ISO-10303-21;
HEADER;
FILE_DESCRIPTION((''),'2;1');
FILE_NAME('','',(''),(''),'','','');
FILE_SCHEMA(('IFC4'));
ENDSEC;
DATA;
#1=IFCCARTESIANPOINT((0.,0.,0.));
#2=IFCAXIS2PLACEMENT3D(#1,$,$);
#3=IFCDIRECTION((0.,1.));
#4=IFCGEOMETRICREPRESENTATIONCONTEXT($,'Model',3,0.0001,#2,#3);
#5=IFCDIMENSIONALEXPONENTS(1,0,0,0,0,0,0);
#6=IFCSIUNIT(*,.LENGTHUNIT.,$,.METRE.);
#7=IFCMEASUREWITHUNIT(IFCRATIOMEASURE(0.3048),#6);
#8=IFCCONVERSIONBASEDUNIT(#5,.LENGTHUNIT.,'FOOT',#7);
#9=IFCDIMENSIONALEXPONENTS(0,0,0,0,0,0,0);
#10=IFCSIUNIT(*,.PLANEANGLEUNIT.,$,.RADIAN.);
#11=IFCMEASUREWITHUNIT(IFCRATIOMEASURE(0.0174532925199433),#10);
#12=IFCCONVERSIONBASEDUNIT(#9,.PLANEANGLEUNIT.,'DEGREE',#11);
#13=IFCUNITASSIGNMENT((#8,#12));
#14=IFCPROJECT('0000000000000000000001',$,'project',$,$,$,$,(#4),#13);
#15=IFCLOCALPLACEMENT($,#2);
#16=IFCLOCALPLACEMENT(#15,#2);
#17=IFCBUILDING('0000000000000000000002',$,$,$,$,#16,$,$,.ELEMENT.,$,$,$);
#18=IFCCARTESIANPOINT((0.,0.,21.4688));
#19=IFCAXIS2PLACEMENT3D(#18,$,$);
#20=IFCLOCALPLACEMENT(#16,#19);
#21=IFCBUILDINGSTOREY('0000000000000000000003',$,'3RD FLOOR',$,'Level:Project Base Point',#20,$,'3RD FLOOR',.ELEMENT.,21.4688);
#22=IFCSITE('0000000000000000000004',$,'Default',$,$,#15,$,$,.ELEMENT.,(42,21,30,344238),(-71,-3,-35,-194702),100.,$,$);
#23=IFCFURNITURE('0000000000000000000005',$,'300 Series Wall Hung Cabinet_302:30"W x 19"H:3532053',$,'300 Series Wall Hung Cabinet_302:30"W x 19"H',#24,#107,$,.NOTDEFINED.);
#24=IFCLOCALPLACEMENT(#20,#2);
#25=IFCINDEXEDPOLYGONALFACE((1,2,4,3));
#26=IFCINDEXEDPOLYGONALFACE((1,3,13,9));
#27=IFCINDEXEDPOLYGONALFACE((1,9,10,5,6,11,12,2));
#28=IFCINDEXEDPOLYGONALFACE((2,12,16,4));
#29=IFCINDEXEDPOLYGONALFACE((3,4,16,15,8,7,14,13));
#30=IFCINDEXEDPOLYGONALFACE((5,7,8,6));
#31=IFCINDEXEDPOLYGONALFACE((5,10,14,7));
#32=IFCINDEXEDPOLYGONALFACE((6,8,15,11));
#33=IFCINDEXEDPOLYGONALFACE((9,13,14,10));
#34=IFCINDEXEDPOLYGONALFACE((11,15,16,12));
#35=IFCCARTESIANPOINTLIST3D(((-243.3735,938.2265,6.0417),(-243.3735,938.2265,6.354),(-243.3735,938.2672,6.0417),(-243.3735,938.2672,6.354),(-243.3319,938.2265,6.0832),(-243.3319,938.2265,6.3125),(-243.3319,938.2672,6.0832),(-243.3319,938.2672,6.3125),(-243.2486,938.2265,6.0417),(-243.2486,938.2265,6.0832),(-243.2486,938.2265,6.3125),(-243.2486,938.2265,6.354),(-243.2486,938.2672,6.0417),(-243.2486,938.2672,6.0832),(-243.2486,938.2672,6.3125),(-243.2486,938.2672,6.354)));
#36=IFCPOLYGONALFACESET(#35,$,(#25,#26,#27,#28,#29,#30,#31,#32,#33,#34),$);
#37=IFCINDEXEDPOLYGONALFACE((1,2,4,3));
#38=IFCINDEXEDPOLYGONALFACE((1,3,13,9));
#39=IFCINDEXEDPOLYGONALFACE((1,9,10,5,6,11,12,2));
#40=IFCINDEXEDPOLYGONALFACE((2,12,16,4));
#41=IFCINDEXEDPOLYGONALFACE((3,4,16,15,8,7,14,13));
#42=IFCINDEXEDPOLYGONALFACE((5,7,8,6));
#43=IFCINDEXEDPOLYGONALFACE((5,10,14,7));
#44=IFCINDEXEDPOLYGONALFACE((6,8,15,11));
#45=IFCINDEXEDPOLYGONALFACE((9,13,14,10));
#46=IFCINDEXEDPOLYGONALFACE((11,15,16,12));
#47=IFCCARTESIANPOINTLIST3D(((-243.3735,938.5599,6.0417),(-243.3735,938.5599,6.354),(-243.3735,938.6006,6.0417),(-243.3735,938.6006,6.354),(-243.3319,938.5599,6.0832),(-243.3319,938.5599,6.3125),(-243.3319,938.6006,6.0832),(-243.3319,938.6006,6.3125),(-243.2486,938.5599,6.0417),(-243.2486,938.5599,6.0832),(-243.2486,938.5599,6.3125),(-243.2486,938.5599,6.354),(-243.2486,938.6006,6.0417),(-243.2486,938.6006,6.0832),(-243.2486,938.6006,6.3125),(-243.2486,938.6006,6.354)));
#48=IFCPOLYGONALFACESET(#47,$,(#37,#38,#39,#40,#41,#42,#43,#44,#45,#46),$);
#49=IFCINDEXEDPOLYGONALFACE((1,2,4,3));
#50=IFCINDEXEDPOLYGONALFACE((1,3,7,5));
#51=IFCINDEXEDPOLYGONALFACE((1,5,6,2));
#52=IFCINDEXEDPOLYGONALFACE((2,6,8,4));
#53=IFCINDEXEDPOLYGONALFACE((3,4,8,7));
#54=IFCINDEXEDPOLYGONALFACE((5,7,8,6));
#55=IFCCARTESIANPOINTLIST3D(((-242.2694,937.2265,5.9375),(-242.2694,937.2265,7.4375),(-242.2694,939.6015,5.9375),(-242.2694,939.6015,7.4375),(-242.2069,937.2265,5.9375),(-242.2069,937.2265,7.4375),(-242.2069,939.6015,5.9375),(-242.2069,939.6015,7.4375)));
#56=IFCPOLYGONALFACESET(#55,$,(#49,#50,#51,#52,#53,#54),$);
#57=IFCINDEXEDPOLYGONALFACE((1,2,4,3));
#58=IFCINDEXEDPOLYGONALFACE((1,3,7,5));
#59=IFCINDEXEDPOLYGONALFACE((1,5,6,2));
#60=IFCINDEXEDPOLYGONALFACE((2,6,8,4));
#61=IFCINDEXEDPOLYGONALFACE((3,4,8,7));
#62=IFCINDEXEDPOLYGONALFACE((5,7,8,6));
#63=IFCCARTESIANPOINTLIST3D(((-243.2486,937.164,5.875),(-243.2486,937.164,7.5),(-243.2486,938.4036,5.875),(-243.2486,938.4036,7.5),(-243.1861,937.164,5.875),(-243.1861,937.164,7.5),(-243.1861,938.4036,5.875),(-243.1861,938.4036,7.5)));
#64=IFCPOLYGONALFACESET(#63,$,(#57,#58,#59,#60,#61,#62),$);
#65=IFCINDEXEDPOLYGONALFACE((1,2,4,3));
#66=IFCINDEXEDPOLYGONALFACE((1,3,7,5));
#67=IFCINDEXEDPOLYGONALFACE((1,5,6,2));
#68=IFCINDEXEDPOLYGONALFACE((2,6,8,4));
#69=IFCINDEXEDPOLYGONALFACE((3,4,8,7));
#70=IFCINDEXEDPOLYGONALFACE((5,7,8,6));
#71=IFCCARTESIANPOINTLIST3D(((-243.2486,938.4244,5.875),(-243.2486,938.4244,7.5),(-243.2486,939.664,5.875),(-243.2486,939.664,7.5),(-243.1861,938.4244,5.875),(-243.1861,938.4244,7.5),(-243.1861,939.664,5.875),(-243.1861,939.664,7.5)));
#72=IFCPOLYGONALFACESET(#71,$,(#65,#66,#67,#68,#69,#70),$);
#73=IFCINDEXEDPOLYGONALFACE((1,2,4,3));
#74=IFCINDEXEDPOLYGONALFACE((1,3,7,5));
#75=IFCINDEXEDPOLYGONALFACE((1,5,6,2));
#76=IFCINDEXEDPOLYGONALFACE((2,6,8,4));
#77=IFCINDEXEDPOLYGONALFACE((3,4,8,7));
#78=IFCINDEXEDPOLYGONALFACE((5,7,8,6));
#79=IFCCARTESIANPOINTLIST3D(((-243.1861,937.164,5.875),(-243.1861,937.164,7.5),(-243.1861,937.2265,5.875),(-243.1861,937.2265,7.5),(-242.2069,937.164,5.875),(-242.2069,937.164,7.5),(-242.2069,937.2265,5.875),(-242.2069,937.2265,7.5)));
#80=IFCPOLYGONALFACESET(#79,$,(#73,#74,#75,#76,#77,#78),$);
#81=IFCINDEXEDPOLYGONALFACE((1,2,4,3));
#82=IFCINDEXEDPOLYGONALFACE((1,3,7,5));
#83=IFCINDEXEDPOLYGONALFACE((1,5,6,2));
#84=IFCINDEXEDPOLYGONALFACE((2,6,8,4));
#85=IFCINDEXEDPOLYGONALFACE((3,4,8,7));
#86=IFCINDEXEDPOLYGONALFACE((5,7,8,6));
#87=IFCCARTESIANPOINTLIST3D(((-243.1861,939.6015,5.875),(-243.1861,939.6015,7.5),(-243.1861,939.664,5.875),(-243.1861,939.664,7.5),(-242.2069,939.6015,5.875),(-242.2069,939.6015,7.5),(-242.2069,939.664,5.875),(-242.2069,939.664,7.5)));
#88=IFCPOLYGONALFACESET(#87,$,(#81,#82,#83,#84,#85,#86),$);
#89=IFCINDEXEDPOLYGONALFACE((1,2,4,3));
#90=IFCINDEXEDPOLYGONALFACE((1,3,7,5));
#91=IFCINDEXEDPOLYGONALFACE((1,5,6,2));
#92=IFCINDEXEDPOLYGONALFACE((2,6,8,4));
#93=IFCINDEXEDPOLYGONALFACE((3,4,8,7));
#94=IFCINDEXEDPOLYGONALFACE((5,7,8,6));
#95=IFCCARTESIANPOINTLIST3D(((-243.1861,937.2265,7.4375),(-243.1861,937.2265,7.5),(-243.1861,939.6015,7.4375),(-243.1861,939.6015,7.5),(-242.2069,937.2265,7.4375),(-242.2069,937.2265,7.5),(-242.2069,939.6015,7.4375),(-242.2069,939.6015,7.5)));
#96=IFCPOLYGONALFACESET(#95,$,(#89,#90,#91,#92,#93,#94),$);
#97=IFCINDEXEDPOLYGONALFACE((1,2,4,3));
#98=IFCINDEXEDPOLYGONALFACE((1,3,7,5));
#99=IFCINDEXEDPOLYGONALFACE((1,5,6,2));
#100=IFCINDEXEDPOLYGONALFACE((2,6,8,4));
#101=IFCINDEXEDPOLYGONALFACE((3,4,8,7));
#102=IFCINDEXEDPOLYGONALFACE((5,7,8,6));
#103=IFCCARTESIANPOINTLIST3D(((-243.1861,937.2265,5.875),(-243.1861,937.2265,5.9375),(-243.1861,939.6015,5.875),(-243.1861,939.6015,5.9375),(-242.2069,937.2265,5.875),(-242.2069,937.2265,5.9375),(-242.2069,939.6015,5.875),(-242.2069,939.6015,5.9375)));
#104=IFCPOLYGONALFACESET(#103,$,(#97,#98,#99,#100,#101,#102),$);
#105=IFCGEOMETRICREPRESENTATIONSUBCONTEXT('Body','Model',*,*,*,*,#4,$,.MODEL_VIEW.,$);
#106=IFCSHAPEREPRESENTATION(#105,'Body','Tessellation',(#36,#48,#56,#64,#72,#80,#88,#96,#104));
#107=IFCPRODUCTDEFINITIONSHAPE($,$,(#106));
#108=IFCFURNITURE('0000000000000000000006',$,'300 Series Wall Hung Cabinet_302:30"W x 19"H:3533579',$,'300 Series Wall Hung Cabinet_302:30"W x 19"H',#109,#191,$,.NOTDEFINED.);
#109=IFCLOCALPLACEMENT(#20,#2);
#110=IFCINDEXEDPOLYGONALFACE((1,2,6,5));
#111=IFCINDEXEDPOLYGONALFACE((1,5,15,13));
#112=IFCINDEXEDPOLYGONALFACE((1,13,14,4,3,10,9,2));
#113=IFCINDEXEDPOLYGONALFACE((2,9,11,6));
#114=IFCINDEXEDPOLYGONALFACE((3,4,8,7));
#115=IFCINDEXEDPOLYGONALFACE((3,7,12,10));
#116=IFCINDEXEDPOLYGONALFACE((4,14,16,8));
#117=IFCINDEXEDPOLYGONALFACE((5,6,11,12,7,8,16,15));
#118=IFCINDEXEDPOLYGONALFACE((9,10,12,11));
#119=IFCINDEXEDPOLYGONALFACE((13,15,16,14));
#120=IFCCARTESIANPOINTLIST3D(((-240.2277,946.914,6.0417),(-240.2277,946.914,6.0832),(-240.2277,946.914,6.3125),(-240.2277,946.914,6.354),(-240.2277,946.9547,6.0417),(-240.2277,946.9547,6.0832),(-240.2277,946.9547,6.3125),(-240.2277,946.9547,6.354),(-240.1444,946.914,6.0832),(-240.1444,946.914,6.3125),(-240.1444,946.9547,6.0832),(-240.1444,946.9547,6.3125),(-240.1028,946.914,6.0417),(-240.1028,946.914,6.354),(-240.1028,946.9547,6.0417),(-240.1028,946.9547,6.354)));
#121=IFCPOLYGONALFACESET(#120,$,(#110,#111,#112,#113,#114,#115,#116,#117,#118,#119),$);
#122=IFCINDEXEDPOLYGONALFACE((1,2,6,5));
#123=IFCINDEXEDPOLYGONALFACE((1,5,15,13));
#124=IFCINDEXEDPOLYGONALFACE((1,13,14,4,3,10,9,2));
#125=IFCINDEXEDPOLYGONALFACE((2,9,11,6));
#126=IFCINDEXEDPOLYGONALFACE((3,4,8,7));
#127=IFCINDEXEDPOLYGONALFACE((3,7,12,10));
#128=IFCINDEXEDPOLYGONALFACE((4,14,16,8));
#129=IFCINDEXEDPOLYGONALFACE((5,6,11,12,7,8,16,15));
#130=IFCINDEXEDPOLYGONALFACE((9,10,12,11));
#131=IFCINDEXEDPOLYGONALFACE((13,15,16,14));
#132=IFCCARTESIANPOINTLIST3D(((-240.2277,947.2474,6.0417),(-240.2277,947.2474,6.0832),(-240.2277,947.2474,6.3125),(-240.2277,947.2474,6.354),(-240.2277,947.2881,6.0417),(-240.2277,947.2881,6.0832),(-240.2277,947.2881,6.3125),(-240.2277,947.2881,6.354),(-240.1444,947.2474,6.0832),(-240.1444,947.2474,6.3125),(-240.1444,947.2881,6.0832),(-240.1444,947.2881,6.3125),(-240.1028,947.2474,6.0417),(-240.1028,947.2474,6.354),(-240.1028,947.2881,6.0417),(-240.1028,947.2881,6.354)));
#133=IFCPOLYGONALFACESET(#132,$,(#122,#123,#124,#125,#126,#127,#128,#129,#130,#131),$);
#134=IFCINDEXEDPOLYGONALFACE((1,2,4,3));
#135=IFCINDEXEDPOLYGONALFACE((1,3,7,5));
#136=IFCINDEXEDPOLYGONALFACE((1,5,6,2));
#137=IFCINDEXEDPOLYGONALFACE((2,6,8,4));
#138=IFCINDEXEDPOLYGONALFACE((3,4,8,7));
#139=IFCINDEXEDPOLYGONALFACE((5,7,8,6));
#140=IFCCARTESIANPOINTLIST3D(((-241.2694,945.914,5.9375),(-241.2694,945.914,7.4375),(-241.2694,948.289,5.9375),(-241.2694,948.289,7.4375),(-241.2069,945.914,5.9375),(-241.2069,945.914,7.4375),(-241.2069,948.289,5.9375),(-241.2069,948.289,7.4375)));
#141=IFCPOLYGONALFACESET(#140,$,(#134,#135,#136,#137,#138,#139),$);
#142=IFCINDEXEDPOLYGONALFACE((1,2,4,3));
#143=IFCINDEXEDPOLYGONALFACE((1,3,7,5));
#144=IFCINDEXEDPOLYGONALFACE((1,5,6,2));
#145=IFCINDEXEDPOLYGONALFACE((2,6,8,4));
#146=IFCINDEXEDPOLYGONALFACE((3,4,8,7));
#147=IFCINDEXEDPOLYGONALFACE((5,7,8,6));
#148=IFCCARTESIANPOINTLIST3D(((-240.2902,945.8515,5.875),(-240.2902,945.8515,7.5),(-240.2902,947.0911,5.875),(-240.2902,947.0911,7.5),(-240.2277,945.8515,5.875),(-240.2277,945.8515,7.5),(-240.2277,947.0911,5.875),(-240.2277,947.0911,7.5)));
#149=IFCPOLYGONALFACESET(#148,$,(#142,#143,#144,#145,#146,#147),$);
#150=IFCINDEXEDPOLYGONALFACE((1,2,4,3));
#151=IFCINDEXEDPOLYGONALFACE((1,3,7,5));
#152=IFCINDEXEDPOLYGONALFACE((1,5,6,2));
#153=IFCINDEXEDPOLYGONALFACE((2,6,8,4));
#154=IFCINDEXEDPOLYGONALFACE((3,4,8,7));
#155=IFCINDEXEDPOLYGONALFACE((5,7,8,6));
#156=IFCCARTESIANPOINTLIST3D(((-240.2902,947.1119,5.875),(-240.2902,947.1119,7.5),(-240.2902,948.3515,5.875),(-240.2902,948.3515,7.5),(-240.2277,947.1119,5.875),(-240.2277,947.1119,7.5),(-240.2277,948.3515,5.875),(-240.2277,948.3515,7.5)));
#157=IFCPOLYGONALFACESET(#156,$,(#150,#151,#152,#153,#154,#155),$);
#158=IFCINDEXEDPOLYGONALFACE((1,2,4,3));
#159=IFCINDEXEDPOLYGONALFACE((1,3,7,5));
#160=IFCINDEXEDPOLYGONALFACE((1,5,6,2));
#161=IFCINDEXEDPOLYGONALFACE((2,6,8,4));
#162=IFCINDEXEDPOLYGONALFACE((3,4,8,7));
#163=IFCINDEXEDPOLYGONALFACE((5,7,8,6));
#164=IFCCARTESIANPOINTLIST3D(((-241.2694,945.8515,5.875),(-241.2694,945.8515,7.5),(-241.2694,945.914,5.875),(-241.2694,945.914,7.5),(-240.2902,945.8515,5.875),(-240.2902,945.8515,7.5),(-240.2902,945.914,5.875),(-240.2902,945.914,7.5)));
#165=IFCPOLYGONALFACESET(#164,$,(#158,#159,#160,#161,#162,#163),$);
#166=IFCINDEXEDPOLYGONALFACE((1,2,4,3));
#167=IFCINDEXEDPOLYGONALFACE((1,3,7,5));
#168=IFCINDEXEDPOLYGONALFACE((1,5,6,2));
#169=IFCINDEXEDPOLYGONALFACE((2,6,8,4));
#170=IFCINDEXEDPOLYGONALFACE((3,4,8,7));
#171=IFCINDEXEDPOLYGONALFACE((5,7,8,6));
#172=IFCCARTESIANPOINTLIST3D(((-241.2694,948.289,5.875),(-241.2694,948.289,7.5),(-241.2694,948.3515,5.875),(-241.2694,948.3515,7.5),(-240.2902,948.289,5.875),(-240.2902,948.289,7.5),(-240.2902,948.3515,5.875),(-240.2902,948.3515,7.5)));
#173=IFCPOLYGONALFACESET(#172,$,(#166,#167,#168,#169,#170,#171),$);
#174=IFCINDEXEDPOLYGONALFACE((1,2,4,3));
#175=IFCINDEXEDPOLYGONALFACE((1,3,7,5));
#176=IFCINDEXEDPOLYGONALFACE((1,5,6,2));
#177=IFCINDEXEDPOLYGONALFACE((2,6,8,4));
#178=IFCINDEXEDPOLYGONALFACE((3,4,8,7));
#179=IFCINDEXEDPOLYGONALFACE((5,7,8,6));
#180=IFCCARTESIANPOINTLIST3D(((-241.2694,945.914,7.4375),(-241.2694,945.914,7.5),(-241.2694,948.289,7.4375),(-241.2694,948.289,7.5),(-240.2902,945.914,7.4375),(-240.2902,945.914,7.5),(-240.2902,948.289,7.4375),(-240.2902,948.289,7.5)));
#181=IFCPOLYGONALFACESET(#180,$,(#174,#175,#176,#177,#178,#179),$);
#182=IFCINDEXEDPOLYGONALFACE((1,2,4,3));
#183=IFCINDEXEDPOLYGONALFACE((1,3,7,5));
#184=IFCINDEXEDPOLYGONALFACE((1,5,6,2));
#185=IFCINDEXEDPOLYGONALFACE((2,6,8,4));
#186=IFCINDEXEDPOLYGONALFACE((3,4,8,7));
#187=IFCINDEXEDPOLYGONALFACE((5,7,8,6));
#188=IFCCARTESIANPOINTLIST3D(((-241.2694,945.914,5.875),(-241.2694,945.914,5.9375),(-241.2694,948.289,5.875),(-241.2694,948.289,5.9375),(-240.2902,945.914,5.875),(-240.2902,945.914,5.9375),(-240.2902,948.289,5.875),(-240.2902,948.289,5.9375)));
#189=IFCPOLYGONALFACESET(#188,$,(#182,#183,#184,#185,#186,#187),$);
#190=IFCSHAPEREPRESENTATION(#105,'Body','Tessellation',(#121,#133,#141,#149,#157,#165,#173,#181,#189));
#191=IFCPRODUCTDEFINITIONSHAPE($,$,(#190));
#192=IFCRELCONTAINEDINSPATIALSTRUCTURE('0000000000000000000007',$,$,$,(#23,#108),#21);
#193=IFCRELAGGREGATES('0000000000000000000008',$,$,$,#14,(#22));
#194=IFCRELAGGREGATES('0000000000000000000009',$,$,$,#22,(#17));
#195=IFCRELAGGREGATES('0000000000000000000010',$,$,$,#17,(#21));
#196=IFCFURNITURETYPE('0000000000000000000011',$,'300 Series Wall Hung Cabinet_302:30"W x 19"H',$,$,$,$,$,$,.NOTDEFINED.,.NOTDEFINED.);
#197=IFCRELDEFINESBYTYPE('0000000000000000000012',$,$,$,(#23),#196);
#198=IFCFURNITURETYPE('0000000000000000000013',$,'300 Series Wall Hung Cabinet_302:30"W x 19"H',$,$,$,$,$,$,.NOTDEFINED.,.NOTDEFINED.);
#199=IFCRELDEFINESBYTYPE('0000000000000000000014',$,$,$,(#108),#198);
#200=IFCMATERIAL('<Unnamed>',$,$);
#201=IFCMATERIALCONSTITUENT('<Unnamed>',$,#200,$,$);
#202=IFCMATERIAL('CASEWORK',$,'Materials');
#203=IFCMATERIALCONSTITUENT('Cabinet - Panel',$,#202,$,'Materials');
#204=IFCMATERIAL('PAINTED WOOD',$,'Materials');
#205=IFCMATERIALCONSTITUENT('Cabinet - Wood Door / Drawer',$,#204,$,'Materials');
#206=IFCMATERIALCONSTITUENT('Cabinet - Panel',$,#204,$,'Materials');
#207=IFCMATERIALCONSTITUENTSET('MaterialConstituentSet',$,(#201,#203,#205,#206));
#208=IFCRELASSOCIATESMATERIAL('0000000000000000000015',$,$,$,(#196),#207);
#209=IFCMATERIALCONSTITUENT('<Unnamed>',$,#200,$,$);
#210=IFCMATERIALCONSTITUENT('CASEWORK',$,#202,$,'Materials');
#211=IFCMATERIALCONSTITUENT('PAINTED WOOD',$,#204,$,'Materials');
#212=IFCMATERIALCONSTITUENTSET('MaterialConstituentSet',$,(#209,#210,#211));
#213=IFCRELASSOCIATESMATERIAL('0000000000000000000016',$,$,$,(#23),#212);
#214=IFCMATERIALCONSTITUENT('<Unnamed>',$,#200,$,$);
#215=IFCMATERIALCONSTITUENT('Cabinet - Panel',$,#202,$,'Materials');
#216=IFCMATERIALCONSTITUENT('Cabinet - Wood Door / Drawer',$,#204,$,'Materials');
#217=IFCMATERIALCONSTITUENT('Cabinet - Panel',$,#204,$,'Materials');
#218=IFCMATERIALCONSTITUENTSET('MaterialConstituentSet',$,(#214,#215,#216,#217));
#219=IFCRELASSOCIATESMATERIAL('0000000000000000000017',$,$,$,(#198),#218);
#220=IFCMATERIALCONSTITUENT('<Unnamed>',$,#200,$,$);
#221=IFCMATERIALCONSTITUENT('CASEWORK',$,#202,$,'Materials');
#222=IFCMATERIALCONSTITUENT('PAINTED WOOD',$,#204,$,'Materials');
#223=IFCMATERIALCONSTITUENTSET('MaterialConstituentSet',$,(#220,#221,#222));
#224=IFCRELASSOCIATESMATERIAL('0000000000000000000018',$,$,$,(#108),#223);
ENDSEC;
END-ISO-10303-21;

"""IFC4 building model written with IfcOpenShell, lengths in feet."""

from ifc_helpers import new_model, entity, si_unit, converted_unit, direction, frame, frame_2d, origin, origin_2d_with_axis, place, context, subcontext, project, spatial, polyline, rectangle, outline, extrude, source, transform, mapped, material, constituent, constituent_set, type_object, type_shapes, element, save


model = new_model("IFC4")

# Units and contexts
model_context = context("Model", 3, precision=0.0001, world=origin(), true_north=direction((0.0, 1.0)))
body_context = subcontext(model_context, "Body", "Model", "MODEL_VIEW")
ifc_project = project(units=[converted_unit("LENGTHUNIT", "FOOT", entity("IfcRatioMeasure", 0.3048), si_unit("LENGTHUNIT", "METRE"), dimensions=[1, 0, 0, 0, 0, 0, 0]), converted_unit("PLANEANGLEUNIT", "DEGREE", entity("IfcRatioMeasure", 0.0174532925199433), si_unit("PLANEANGLEUNIT", "RADIAN"), dimensions=[0, 0, 0, 0, 0, 0, 0])], contexts=[model_context])

# Site, building, storey
site_placement = place(None, origin())
site = spatial("IfcSite", under=ifc_project, at=site_placement, Name="Default", CompositionType="ELEMENT", RefLatitude=(42, 21, 30, 344238), RefLongitude=(-71, -3, -35, -194702), RefElevation=100.0)
building_placement = place(site_placement, origin())
building = spatial("IfcBuilding", under=site, at=building_placement, CompositionType="ELEMENT")
storey_placement = place(building_placement, frame((0.0, 0.0, 21.4688)))
storey = spatial("IfcBuildingStorey", under=building, at=storey_placement, Name="3RD FLOOR", ObjectType="Level:Project Base Point", LongName="3RD FLOOR", CompositionType="ELEMENT", Elevation=21.4688)

# Furniture
ifc_material_1 = material(Name="CASEWORK", Category="Materials")
ifc_material_2 = material(Name="<Unnamed>")
ifc_material_3 = material(Name="PAINTED WOOD", Category="Materials")
ifc_constituent_1 = constituent(ifc_material_2, Name="<Unnamed>")
ifc_constituent_2 = constituent(ifc_material_1, Name="CASEWORK", Category="Materials")
ifc_constituent_3 = constituent(ifc_material_3, Name="PAINTED WOOD", Category="Materials")
ifc_constituent_set_1 = constituent_set(constituents=[ifc_constituent_1, ifc_constituent_2, ifc_constituent_3], Name="MaterialConstituentSet")
ifc_constituent_4 = constituent(ifc_material_2, Name="<Unnamed>")
ifc_constituent_5 = constituent(ifc_material_1, Name="Cabinet - Panel", Category="Materials")
ifc_constituent_6 = constituent(ifc_material_3, Name="Cabinet - Wood Door / Drawer", Category="Materials")
ifc_constituent_7 = constituent(ifc_material_3, Name="Cabinet - Panel", Category="Materials")
ifc_constituent_set_2 = constituent_set(constituents=[ifc_constituent_4, ifc_constituent_5, ifc_constituent_6, ifc_constituent_7], Name="MaterialConstituentSet")
furniture_type_1 = type_object("IfcFurnitureType", Name="300 Series Wall Hung Cabinet_302:30\"W x 19\"H", AssemblyPlace="NOTDEFINED", PredefinedType="NOTDEFINED", material=ifc_constituent_set_2)
shared_shape_1 = source(origin(), body_context, "Body", "SweptSolid", [
    extrude(outline(polyline([(-0.0521, -0.1146), (-0.0521, -0.1562), (0.0729, -0.1562), (0.0729, 0.1562), (-0.0521, 0.1562), (-0.0521, 0.1146), (0.0313, 0.1146), (0.0313, -0.1146), (-0.0521, -0.1146)])), frame((1.0625, 1.0937, 0.3229), z_axis=(-1.0, 0.0, 0.0), x_axis=(0.0, 1.0, 0.0)), (0.0, 0.0, -1.0), 0.0407),
    extrude(outline(polyline([(-0.0521, -0.1146), (-0.0521, -0.1562), (0.0729, -0.1562), (0.0729, 0.1562), (-0.0521, 0.1562), (-0.0521, 0.1146), (0.0313, 0.1146), (0.0313, -0.1146), (-0.0521, -0.1146)])), frame((1.3958, 1.0937, 0.3229), z_axis=(-1.0, 0.0, 0.0), x_axis=(0.0, 1.0, 0.0)), (0.0, 0.0, -1.0), 0.0407),
    extrude(rectangle(XDim=0.0625, YDim=2.375, at=frame_2d((0.0, 0.0), x_axis=(1.0, 0.0))), frame((1.25, 0.0313, 0.0625), z_axis=(0.0, 0.0, 1.0), x_axis=(0.0, 1.0, 0.0)), (0.0, 0.0, 1.0), 1.5),
    extrude(rectangle(XDim=0.0625, YDim=1.2396, at=origin_2d_with_axis()), frame((0.6198, 1.0104, 0.0), z_axis=(0.0, 0.0, 1.0), x_axis=(0.0, 1.0, 0.0)), (0.0, 0.0, 1.0), 1.625),
    extrude(rectangle(XDim=0.0625, YDim=1.2396, at=frame_2d((0.0, 0.0), x_axis=(1.0, 0.0))), frame((1.8802, 1.0104, 0.0), z_axis=(0.0, 0.0, 1.0), x_axis=(0.0, 1.0, 0.0)), (0.0, 0.0, 1.0), 1.625),
    extrude(rectangle(XDim=0.0625, YDim=0.9792, at=frame_2d((0.0, 0.0), x_axis=(1.0, 0.0))), frame((0.0313, 0.4896, 0.0)), (0.0, 0.0, 1.0), 1.625),
    extrude(rectangle(XDim=0.0625, YDim=0.9792, at=frame_2d((0.0, 0.0), x_axis=(1.0, 0.0))), frame((2.4688, 0.4896, 0.0)), (0.0, 0.0, 1.0), 1.625),
    extrude(rectangle(XDim=2.375, YDim=0.9792, at=frame_2d((0.0, 0.0), x_axis=(1.0, 0.0))), frame((1.25, 0.4896, 1.5625), z_axis=(0.0, 0.0, 1.0), x_axis=(-1.0, 0.0, 0.0)), (0.0, 0.0, 1.0), 0.0625),
    extrude(rectangle(XDim=2.375, YDim=0.9792, at=frame_2d((0.0, 0.0), x_axis=(1.0, 0.0))), frame((1.25, 0.4896, 0.0), z_axis=(0.0, 0.0, 1.0), x_axis=(-1.0, 0.0, 0.0)), (0.0, 0.0, 1.0), 0.0625),
])
type_shapes(furniture_type_1, [shared_shape_1])
furniture_1_placement = place(storey_placement, frame((-242.2069, 937.164, 5.875), z_axis=(0.0, 0.0, 1.0), x_axis=(0.0, 1.0, 0.0)))
element("IfcFurniture", 1, at=furniture_1_placement, inside=storey, type_object=furniture_type_1, material=ifc_constituent_set_1, Name="300 Series Wall Hung Cabinet_302:30\"W x 19\"H:3532053", ObjectType="300 Series Wall Hung Cabinet_302:30\"W x 19\"H", PredefinedType="NOTDEFINED", context=body_context, shape_type="MappedRepresentation", body=[
    mapped(shared_shape_1, transform((0.0, 0.0, 0.0), scale=1.0)),
])
ifc_constituent_8 = constituent(ifc_material_2, Name="<Unnamed>")
ifc_constituent_9 = constituent(ifc_material_1, Name="CASEWORK", Category="Materials")
ifc_constituent_10 = constituent(ifc_material_3, Name="PAINTED WOOD", Category="Materials")
ifc_constituent_set_3 = constituent_set(constituents=[ifc_constituent_8, ifc_constituent_9, ifc_constituent_10], Name="MaterialConstituentSet")
ifc_constituent_11 = constituent(ifc_material_2, Name="<Unnamed>")
ifc_constituent_12 = constituent(ifc_material_1, Name="Cabinet - Panel", Category="Materials")
ifc_constituent_13 = constituent(ifc_material_3, Name="Cabinet - Wood Door / Drawer", Category="Materials")
ifc_constituent_14 = constituent(ifc_material_3, Name="Cabinet - Panel", Category="Materials")
ifc_constituent_set_4 = constituent_set(constituents=[ifc_constituent_11, ifc_constituent_12, ifc_constituent_13, ifc_constituent_14], Name="MaterialConstituentSet")
furniture_type_2 = type_object("IfcFurnitureType", Name="300 Series Wall Hung Cabinet_302:30\"W x 19\"H", AssemblyPlace="NOTDEFINED", PredefinedType="NOTDEFINED", material=ifc_constituent_set_4)
shared_shape_2 = source(origin(), body_context, "Body", "SweptSolid", [
    extrude(outline(polyline([(0.1146, -0.0521), (0.1562, -0.0521), (0.1562, 0.0729), (-0.1562, 0.0729), (-0.1562, -0.0521), (-0.1146, -0.0521), (-0.1146, 0.0313), (0.1146, 0.0313), (0.1146, -0.0521)])), frame((1.0625, 0.0729, 0.3229), z_axis=(1.0, 0.0, 0.0), x_axis=(0.0, 0.0, 1.0)), (0.0, 0.0, 1.0), 0.0407),
    extrude(outline(polyline([(0.1146, -0.0521), (0.1562, -0.0521), (0.1562, 0.0729), (-0.1562, 0.0729), (-0.1562, -0.0521), (-0.1146, -0.0521), (-0.1146, 0.0313), (0.1146, 0.0313), (0.1146, -0.0521)])), frame((1.3958, 0.0729, 0.3229), z_axis=(1.0, 0.0, 0.0), x_axis=(0.0, 0.0, 1.0)), (0.0, 0.0, 1.0), 0.0407),
    extrude(rectangle(XDim=2.375, YDim=0.0625, at=origin_2d_with_axis()), frame((1.25, 1.1354, 0.0625), z_axis=(0.0, 0.0, 1.0), x_axis=(-1.0, 0.0, 0.0)), (0.0, 0.0, 1.0), 1.5),
    extrude(rectangle(XDim=1.2396, YDim=0.0625, at=origin_2d_with_axis()), frame((0.6198, 0.1562, 0.0), z_axis=(0.0, 0.0, 1.0), x_axis=(-1.0, 0.0, 0.0)), (0.0, 0.0, 1.0), 1.625),
    extrude(rectangle(XDim=1.2396, YDim=0.0625, at=frame_2d((0.0, 0.0), x_axis=(1.0, 0.0))), frame((1.8802, 0.1562, 0.0), z_axis=(0.0, 0.0, 1.0), x_axis=(-1.0, 0.0, 0.0)), (0.0, 0.0, 1.0), 1.625),
    extrude(rectangle(XDim=0.9792, YDim=0.0625, at=frame_2d((0.0, 0.0), x_axis=(1.0, 0.0))), frame((0.0313, 0.677, 0.0), z_axis=(0.0, 0.0, 1.0), x_axis=(0.0, -1.0, 0.0)), (0.0, 0.0, 1.0), 1.625),
    extrude(rectangle(XDim=0.9792, YDim=0.0625, at=frame_2d((0.0, 0.0), x_axis=(1.0, 0.0))), frame((2.4688, 0.677, 0.0), z_axis=(0.0, 0.0, 1.0), x_axis=(0.0, -1.0, 0.0)), (0.0, 0.0, 1.0), 1.625),
    extrude(rectangle(XDim=0.9792, YDim=2.375, at=frame_2d((0.0, 0.0), x_axis=(1.0, 0.0))), frame((1.25, 0.677, 1.5625), z_axis=(0.0, 0.0, 1.0), x_axis=(0.0, 1.0, 0.0)), (0.0, 0.0, 1.0), 0.0625),
    extrude(rectangle(XDim=0.9792, YDim=2.375, at=frame_2d((0.0, 0.0), x_axis=(1.0, 0.0))), frame((1.25, 0.677, 0.0), z_axis=(0.0, 0.0, 1.0), x_axis=(0.0, 1.0, 0.0)), (0.0, 0.0, 1.0), 0.0625),
])
type_shapes(furniture_type_2, [shared_shape_2])
furniture_2_placement = place(storey_placement, frame((-240.1028, 945.8515, 5.875), z_axis=(0.0, 0.0, 1.0), x_axis=(0.0, 1.0, 0.0)))
element("IfcFurniture", 2, at=furniture_2_placement, inside=storey, type_object=furniture_type_2, material=ifc_constituent_set_3, Name="300 Series Wall Hung Cabinet_302:30\"W x 19\"H:3533579", ObjectType="300 Series Wall Hung Cabinet_302:30\"W x 19\"H", PredefinedType="NOTDEFINED", context=body_context, shape_type="MappedRepresentation", body=[
    mapped(shared_shape_2, transform((0.0, 0.0, 0.0), scale=1.0)),
])

save(model, "model.ifc")
